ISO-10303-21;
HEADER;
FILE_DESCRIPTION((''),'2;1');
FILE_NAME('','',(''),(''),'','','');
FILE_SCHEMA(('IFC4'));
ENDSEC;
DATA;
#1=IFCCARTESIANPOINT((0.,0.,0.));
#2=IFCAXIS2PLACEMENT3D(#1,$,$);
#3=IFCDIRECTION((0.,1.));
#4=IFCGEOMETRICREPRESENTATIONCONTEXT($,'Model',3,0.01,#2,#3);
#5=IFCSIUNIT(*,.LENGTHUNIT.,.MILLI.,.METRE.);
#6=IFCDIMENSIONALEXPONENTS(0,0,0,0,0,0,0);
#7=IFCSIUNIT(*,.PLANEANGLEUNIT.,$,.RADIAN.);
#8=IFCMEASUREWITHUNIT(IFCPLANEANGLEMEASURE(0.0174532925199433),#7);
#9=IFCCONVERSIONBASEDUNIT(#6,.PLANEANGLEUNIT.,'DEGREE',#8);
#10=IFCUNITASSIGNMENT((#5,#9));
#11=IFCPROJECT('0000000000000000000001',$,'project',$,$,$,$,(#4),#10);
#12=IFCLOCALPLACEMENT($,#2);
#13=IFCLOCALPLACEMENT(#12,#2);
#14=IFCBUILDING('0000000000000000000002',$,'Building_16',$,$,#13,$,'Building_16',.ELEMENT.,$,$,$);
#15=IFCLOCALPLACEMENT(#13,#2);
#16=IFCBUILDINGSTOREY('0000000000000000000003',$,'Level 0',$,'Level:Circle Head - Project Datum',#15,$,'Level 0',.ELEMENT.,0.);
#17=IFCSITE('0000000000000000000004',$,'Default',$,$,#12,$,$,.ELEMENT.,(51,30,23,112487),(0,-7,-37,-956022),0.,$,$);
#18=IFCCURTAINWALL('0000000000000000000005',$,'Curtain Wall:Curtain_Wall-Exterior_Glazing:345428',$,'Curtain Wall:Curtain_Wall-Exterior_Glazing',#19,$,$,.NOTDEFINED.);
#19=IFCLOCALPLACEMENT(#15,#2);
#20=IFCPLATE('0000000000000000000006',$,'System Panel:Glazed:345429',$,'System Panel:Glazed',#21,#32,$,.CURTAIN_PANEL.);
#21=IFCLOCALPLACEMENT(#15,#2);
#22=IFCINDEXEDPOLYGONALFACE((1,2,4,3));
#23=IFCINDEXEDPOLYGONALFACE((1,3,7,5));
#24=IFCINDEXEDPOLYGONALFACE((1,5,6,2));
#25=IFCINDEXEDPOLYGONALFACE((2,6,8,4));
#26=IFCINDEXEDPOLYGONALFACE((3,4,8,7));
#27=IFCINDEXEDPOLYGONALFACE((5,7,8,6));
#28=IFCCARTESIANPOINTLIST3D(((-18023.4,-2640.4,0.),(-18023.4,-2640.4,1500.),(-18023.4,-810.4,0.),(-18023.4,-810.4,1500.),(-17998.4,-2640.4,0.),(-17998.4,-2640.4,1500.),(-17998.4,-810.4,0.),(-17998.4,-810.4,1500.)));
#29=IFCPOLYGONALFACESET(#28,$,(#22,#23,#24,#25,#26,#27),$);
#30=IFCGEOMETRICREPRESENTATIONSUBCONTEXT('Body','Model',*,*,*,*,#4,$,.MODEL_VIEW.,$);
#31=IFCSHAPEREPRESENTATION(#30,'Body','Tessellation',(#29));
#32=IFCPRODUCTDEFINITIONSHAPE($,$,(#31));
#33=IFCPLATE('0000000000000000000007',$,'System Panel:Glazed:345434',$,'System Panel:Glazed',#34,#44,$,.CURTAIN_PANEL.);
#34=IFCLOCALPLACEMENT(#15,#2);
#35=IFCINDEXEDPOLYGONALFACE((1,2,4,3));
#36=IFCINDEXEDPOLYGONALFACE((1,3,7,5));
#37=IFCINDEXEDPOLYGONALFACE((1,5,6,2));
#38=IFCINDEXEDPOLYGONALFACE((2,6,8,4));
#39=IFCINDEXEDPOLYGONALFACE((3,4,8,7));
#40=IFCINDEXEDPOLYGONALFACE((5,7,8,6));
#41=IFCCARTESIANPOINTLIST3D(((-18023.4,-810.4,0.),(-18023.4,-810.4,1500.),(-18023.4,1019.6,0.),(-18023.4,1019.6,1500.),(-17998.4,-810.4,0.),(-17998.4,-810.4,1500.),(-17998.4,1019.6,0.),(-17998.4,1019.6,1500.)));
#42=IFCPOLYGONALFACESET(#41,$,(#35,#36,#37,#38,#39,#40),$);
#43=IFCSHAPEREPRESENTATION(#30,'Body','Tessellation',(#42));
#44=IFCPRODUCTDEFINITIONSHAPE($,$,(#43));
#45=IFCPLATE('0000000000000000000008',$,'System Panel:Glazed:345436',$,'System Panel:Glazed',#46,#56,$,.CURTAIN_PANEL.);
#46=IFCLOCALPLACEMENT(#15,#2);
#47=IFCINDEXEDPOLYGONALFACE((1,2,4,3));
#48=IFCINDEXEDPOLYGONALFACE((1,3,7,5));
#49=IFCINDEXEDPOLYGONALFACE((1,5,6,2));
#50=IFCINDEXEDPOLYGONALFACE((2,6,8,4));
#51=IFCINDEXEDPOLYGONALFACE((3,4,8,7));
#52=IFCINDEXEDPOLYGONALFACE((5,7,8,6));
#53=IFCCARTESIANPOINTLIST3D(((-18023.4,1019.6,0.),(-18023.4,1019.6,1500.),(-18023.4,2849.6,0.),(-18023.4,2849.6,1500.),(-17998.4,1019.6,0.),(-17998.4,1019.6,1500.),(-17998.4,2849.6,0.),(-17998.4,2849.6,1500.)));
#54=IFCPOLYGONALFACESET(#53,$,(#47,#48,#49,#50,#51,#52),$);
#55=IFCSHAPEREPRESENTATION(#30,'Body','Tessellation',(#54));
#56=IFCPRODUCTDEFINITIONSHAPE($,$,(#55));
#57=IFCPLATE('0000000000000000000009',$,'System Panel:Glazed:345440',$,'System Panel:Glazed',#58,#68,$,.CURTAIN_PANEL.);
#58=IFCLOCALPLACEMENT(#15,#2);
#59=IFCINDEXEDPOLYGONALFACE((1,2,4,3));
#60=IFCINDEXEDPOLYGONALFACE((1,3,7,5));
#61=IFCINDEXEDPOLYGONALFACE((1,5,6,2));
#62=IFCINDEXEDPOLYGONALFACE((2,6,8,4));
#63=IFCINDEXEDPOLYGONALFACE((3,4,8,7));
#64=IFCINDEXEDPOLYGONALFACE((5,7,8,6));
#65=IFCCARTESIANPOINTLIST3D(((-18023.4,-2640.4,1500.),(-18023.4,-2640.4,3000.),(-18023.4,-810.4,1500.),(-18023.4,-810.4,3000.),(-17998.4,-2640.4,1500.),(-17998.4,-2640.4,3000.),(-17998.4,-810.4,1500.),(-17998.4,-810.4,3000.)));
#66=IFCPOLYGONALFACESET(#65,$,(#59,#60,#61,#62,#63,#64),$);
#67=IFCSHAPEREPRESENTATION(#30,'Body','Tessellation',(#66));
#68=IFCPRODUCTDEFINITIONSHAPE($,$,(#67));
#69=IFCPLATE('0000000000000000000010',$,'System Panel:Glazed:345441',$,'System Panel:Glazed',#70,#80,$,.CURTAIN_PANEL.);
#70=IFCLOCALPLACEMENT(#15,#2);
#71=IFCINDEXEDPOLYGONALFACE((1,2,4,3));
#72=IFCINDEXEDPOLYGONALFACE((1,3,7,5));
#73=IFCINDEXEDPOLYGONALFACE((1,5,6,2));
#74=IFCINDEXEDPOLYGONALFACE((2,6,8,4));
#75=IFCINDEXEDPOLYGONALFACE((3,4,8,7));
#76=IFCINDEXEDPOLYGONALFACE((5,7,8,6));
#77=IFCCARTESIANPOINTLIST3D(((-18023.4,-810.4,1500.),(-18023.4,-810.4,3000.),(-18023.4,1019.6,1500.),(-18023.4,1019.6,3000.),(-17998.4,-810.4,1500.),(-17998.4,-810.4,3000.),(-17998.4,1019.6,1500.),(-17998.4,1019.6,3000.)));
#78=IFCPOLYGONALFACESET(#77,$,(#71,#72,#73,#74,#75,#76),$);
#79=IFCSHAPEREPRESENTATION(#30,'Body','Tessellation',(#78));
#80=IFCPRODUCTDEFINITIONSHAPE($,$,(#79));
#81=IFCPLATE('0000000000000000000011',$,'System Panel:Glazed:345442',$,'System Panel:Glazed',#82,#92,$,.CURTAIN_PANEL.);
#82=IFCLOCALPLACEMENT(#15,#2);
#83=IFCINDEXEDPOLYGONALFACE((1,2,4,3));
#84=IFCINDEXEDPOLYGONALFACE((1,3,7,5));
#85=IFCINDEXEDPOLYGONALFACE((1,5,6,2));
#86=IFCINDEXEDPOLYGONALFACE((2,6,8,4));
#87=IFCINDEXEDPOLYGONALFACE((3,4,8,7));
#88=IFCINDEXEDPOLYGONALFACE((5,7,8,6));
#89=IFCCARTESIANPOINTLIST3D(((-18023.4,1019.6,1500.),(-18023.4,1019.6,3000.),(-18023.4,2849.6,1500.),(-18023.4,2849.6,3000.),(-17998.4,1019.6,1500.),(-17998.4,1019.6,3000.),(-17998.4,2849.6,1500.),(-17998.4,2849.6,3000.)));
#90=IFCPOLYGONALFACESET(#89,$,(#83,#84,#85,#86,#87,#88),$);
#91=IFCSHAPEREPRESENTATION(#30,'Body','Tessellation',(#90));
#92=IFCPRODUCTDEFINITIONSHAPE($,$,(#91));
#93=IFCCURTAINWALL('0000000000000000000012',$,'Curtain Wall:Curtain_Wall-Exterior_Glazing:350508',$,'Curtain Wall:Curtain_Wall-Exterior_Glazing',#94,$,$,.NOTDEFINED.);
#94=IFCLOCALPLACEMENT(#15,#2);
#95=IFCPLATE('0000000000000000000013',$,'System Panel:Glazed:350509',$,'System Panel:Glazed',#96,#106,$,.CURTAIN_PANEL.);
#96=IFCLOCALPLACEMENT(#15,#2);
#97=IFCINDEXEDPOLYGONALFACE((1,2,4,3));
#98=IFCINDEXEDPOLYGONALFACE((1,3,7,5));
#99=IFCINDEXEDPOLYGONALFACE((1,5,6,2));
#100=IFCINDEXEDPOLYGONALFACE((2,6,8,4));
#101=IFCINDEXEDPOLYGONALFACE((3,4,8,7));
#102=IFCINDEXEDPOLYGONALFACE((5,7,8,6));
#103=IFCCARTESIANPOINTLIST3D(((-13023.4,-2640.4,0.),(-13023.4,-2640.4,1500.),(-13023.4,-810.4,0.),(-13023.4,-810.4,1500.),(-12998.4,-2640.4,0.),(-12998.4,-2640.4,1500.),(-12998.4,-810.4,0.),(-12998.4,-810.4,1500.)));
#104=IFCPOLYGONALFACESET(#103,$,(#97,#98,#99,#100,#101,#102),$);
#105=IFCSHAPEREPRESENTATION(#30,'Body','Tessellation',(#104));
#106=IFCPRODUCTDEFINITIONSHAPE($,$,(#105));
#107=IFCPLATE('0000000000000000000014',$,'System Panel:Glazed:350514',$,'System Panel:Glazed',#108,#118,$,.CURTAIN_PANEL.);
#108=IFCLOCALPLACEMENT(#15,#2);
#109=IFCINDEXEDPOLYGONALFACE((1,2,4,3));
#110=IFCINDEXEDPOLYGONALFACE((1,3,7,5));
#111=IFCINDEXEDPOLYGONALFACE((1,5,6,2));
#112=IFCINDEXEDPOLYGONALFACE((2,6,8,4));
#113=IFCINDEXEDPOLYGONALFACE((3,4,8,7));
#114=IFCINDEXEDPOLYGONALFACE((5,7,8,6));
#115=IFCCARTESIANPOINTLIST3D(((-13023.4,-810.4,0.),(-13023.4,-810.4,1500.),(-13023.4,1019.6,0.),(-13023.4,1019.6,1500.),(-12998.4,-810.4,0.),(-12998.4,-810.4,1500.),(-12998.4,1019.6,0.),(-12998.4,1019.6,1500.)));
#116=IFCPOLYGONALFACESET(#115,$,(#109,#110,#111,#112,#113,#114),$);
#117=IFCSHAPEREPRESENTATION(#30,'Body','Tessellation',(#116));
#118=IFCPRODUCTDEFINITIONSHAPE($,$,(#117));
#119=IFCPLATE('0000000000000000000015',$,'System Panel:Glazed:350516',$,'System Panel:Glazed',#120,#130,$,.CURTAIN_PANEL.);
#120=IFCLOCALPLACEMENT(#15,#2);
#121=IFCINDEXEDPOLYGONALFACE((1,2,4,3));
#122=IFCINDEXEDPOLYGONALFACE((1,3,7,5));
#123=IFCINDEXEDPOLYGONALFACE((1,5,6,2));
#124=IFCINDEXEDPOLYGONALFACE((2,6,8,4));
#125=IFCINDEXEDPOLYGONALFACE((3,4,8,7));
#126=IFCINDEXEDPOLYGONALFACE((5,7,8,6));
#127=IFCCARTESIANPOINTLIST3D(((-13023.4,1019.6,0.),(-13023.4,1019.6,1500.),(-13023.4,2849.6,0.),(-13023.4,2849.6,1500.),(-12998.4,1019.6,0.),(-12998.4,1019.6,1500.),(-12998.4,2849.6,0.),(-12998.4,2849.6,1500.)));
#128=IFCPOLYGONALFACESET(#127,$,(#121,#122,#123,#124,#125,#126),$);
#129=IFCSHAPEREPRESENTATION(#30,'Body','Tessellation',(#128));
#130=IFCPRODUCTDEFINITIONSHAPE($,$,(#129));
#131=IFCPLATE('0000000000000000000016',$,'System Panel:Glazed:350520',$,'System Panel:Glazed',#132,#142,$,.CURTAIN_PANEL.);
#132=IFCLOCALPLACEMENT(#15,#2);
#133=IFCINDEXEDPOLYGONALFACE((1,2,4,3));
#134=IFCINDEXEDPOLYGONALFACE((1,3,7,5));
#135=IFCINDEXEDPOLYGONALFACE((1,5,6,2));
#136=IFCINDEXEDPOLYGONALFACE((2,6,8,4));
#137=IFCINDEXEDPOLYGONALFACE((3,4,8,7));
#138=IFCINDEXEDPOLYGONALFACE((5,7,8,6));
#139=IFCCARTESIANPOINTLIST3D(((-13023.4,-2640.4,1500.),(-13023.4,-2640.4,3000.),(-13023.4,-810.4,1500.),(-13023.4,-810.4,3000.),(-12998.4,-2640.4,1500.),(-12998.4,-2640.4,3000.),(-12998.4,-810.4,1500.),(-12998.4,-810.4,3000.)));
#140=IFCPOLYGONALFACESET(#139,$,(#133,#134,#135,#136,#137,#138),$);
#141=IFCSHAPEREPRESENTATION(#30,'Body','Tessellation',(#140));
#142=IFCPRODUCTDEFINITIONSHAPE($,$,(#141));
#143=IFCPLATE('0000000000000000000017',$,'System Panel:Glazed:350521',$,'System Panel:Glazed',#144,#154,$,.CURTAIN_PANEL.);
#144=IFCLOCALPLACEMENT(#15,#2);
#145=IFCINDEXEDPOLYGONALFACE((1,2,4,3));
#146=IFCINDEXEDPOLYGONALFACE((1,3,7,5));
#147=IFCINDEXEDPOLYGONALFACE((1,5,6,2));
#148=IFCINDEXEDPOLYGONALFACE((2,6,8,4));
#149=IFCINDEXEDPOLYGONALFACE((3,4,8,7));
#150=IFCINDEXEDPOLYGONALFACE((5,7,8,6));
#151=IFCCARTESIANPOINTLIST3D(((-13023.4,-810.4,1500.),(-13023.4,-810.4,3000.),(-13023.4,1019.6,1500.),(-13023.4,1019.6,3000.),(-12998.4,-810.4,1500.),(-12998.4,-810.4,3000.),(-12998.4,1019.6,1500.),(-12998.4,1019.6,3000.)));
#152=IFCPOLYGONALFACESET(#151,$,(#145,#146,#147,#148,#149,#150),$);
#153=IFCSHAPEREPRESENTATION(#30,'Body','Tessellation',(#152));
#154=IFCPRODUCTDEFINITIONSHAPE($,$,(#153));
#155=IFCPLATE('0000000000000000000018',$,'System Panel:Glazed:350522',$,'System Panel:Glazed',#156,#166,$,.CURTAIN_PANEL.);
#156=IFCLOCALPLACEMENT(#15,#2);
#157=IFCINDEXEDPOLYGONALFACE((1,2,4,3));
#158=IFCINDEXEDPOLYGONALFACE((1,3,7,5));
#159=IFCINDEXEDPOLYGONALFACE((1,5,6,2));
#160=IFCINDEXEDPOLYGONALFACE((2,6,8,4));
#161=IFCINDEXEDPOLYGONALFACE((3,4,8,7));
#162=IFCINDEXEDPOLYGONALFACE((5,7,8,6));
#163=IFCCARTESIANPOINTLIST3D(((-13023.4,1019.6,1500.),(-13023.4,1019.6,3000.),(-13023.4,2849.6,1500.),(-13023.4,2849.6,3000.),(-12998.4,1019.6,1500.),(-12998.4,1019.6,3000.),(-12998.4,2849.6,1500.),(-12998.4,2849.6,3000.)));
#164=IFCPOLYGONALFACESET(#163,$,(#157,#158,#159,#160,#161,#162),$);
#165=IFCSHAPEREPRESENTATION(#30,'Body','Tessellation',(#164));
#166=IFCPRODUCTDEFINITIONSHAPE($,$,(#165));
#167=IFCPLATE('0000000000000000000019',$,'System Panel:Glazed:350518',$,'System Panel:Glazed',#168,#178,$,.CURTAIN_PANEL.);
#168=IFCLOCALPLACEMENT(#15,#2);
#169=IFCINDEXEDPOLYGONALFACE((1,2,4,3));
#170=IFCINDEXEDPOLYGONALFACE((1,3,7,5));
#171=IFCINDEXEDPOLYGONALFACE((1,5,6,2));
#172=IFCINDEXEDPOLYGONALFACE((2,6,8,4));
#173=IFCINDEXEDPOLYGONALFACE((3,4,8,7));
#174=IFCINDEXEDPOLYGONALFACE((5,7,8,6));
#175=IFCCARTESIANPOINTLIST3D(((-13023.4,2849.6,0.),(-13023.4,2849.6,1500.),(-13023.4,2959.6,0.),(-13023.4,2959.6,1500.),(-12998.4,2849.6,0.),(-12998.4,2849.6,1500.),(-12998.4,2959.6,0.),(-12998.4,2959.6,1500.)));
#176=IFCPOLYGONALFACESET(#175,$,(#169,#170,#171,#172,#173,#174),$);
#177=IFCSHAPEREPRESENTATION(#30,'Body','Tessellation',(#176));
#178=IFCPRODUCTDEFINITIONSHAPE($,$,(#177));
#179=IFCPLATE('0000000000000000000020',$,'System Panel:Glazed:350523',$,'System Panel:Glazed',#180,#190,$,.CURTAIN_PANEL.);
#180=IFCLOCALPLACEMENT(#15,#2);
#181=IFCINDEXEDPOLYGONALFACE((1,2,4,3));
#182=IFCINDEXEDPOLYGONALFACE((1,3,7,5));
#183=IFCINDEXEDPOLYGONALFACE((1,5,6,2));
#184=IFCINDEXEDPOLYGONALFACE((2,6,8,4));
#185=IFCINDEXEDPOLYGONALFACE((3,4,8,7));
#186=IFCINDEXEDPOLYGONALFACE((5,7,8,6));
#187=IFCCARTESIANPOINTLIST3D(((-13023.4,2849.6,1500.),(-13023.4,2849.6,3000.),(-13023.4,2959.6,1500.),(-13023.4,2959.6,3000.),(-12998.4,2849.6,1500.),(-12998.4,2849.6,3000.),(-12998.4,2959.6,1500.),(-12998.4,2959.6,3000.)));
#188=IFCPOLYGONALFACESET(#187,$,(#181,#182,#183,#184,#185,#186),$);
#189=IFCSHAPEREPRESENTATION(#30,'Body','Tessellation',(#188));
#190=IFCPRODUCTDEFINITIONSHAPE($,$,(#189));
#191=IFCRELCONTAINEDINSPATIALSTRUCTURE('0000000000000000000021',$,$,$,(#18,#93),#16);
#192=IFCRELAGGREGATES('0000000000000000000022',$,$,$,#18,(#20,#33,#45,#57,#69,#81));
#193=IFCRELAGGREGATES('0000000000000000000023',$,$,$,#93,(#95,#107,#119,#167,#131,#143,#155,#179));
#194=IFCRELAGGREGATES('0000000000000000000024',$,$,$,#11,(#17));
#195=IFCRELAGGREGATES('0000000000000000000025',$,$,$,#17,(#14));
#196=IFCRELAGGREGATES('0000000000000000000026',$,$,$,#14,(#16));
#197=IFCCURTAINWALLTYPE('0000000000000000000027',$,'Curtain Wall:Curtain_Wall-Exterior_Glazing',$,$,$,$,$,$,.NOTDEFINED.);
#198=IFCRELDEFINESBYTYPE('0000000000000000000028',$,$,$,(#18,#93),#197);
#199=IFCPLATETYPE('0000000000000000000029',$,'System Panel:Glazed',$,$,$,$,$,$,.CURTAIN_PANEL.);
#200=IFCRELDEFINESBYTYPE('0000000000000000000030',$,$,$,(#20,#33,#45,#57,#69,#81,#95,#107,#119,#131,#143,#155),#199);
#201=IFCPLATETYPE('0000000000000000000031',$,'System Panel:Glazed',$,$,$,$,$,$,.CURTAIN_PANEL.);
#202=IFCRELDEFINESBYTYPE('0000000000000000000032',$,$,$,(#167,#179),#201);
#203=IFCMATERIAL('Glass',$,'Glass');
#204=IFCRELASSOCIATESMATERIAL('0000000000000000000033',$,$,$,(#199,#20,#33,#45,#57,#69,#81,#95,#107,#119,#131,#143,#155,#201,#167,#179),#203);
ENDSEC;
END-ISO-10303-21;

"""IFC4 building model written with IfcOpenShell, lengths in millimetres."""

from ifc_helpers import new_model, entity, si_unit, converted_unit, direction, frame, origin, place, context, subcontext, project, spatial, indexed_curve, outline, extrude, source, transform, mapped, material, type_object, type_shapes, element, aggregate, save


model = new_model("IFC4")

# Units and contexts
model_context = context("Model", 3, precision=0.01, world=origin(), true_north=direction((0.0, 1.0)))
body_context = subcontext(model_context, "Body", "Model", "MODEL_VIEW")
ifc_project = project(units=[si_unit("LENGTHUNIT", "METRE", prefix="MILLI"), converted_unit("PLANEANGLEUNIT", "DEGREE", entity("IfcPlaneAngleMeasure", 0.0174532925199433), si_unit("PLANEANGLEUNIT", "RADIAN"), dimensions=[0, 0, 0, 0, 0, 0, 0])], contexts=[model_context])

# Site, building, storey
site_placement = place(None, origin())
site = spatial("IfcSite", under=ifc_project, at=site_placement, Name="Default", CompositionType="ELEMENT", RefLatitude=(51, 30, 23, 112487), RefLongitude=(0, -7, -37, -956022), RefElevation=0.0)
building_placement = place(site_placement, origin())
building = spatial("IfcBuilding", under=site, at=building_placement, Name="Building_16", LongName="Building_16", CompositionType="ELEMENT")
storey_placement = place(building_placement, origin())
storey = spatial("IfcBuildingStorey", under=building, at=storey_placement, Name="Level 0", ObjectType="Level:Circle Head - Project Datum", LongName="Level 0", CompositionType="ELEMENT", Elevation=0.0)

# Curtain walls, plates
curtain_wall_type = type_object("IfcCurtainWallType", Name="Curtain Wall:Curtain_Wall-Exterior_Glazing", PredefinedType="NOTDEFINED")
curtain_wall_1_placement = place(storey_placement, origin())
curtain_wall_1 = element("IfcCurtainWall", 1, at=curtain_wall_1_placement, inside=storey, type_object=curtain_wall_type, Name="Curtain Wall:Curtain_Wall-Exterior_Glazing:345428", ObjectType="Curtain Wall:Curtain_Wall-Exterior_Glazing", PredefinedType="NOTDEFINED")
ifc_material = material(Name="Glass", Category="Glass")
plate_type_1 = type_object("IfcPlateType", Name="System Panel:Glazed", PredefinedType="CURTAIN_PANEL", material=ifc_material)
shared_shape_1 = source(origin(), body_context, "Body", "SweptSolid", [
    extrude(outline(indexed_curve([(-12.5, -915.0), (12.5, -915.0), (12.5, 915.0), (-12.5, 915.0), (-12.5, -915.0)], self_intersect=False)), frame((0.0, 37.0, 0.0), z_axis=(0.0, 0.0, 1.0), x_axis=(0.0, 1.0, 0.0)), (0.0, 0.0, 1.0), 1500.0),
])
type_shapes(plate_type_1, [shared_shape_1])
plate_1_placement = place(curtain_wall_1_placement, frame((-17973.9, -1725.4, 0.0), z_axis=(0.0, 0.0, 1.0), x_axis=(0.0, 1.0, 0.0)))
plate_1 = element("IfcPlate", 2, at=plate_1_placement, type_object=plate_type_1, material=ifc_material, Name="System Panel:Glazed:345429", ObjectType="System Panel:Glazed", PredefinedType="CURTAIN_PANEL", context=body_context, shape_type="MappedRepresentation", body=[
    mapped(shared_shape_1, transform((0.0, 0.0, 0.0), scale=1.0)),
])
plate_2_placement = place(curtain_wall_1_placement, frame((-17973.9, 104.6, 0.0), z_axis=(0.0, 0.0, 1.0), x_axis=(0.0, 1.0, 0.0)))
plate_2 = element("IfcPlate", 3, at=plate_2_placement, type_object=plate_type_1, material=ifc_material, Name="System Panel:Glazed:345434", ObjectType="System Panel:Glazed", PredefinedType="CURTAIN_PANEL", context=body_context, shape_type="MappedRepresentation", body=[
    mapped(shared_shape_1, transform((0.0, 0.0, 0.0), scale=1.0)),
])
plate_3_placement = place(curtain_wall_1_placement, frame((-17973.9, 1934.6, 0.0), z_axis=(0.0, 0.0, 1.0), x_axis=(0.0, 1.0, 0.0)))
plate_3 = element("IfcPlate", 4, at=plate_3_placement, type_object=plate_type_1, material=ifc_material, Name="System Panel:Glazed:345436", ObjectType="System Panel:Glazed", PredefinedType="CURTAIN_PANEL", context=body_context, shape_type="MappedRepresentation", body=[
    mapped(shared_shape_1, transform((0.0, 0.0, 0.0), scale=1.0)),
])
plate_4_placement = place(curtain_wall_1_placement, frame((-17973.9, -1725.4, 1500.0), z_axis=(0.0, 0.0, 1.0), x_axis=(0.0, 1.0, 0.0)))
plate_4 = element("IfcPlate", 5, at=plate_4_placement, type_object=plate_type_1, material=ifc_material, Name="System Panel:Glazed:345440", ObjectType="System Panel:Glazed", PredefinedType="CURTAIN_PANEL", context=body_context, shape_type="MappedRepresentation", body=[
    mapped(shared_shape_1, transform((0.0, 0.0, 0.0), scale=1.0)),
])
plate_5_placement = place(curtain_wall_1_placement, frame((-17973.9, 104.6, 1500.0), z_axis=(0.0, 0.0, 1.0), x_axis=(0.0, 1.0, 0.0)))
plate_5 = element("IfcPlate", 6, at=plate_5_placement, type_object=plate_type_1, material=ifc_material, Name="System Panel:Glazed:345441", ObjectType="System Panel:Glazed", PredefinedType="CURTAIN_PANEL", context=body_context, shape_type="MappedRepresentation", body=[
    mapped(shared_shape_1, transform((0.0, 0.0, 0.0), scale=1.0)),
])
plate_6_placement = place(curtain_wall_1_placement, frame((-17973.9, 1934.6, 1500.0), z_axis=(0.0, 0.0, 1.0), x_axis=(0.0, 1.0, 0.0)))
plate_6 = element("IfcPlate", 7, at=plate_6_placement, type_object=plate_type_1, material=ifc_material, Name="System Panel:Glazed:345442", ObjectType="System Panel:Glazed", PredefinedType="CURTAIN_PANEL", context=body_context, shape_type="MappedRepresentation", body=[
    mapped(shared_shape_1, transform((0.0, 0.0, 0.0), scale=1.0)),
])
curtain_wall_2_placement = place(storey_placement, origin())
curtain_wall_2 = element("IfcCurtainWall", 8, at=curtain_wall_2_placement, inside=storey, type_object=curtain_wall_type, Name="Curtain Wall:Curtain_Wall-Exterior_Glazing:350508", ObjectType="Curtain Wall:Curtain_Wall-Exterior_Glazing", PredefinedType="NOTDEFINED")
plate_7_placement = place(curtain_wall_2_placement, frame((-12973.9, -1725.4, 0.0), z_axis=(0.0, 0.0, 1.0), x_axis=(0.0, 1.0, 0.0)))
plate_7 = element("IfcPlate", 9, at=plate_7_placement, type_object=plate_type_1, material=ifc_material, Name="System Panel:Glazed:350509", ObjectType="System Panel:Glazed", PredefinedType="CURTAIN_PANEL", context=body_context, shape_type="MappedRepresentation", body=[
    mapped(shared_shape_1, transform((0.0, 0.0, 0.0), scale=1.0)),
])
plate_8_placement = place(curtain_wall_2_placement, frame((-12973.9, 104.6, 0.0), z_axis=(0.0, 0.0, 1.0), x_axis=(0.0, 1.0, 0.0)))
plate_8 = element("IfcPlate", 10, at=plate_8_placement, type_object=plate_type_1, material=ifc_material, Name="System Panel:Glazed:350514", ObjectType="System Panel:Glazed", PredefinedType="CURTAIN_PANEL", context=body_context, shape_type="MappedRepresentation", body=[
    mapped(shared_shape_1, transform((0.0, 0.0, 0.0), scale=1.0)),
])
plate_9_placement = place(curtain_wall_2_placement, frame((-12973.9, 1934.6, 0.0), z_axis=(0.0, 0.0, 1.0), x_axis=(0.0, 1.0, 0.0)))
plate_9 = element("IfcPlate", 11, at=plate_9_placement, type_object=plate_type_1, material=ifc_material, Name="System Panel:Glazed:350516", ObjectType="System Panel:Glazed", PredefinedType="CURTAIN_PANEL", context=body_context, shape_type="MappedRepresentation", body=[
    mapped(shared_shape_1, transform((0.0, 0.0, 0.0), scale=1.0)),
])
plate_10_placement = place(curtain_wall_2_placement, frame((-12973.9, -1725.4, 1500.0), z_axis=(0.0, 0.0, 1.0), x_axis=(0.0, 1.0, 0.0)))
plate_10 = element("IfcPlate", 12, at=plate_10_placement, type_object=plate_type_1, material=ifc_material, Name="System Panel:Glazed:350520", ObjectType="System Panel:Glazed", PredefinedType="CURTAIN_PANEL", context=body_context, shape_type="MappedRepresentation", body=[
    mapped(shared_shape_1, transform((0.0, 0.0, 0.0), scale=1.0)),
])
plate_11_placement = place(curtain_wall_2_placement, frame((-12973.9, 104.6, 1500.0), z_axis=(0.0, 0.0, 1.0), x_axis=(0.0, 1.0, 0.0)))
plate_11 = element("IfcPlate", 13, at=plate_11_placement, type_object=plate_type_1, material=ifc_material, Name="System Panel:Glazed:350521", ObjectType="System Panel:Glazed", PredefinedType="CURTAIN_PANEL", context=body_context, shape_type="MappedRepresentation", body=[
    mapped(shared_shape_1, transform((0.0, 0.0, 0.0), scale=1.0)),
])
plate_12_placement = place(curtain_wall_2_placement, frame((-12973.9, 1934.6, 1500.0), z_axis=(0.0, 0.0, 1.0), x_axis=(0.0, 1.0, 0.0)))
plate_12 = element("IfcPlate", 14, at=plate_12_placement, type_object=plate_type_1, material=ifc_material, Name="System Panel:Glazed:350522", ObjectType="System Panel:Glazed", PredefinedType="CURTAIN_PANEL", context=body_context, shape_type="MappedRepresentation", body=[
    mapped(shared_shape_1, transform((0.0, 0.0, 0.0), scale=1.0)),
])
plate_type_2 = type_object("IfcPlateType", Name="System Panel:Glazed", PredefinedType="CURTAIN_PANEL", material=ifc_material)
shared_shape_2 = source(origin(), body_context, "Body", "SweptSolid", [
    extrude(outline(indexed_curve([(-12.5, -55.0), (12.5, -55.0), (12.5, 55.0), (-12.5, 55.0), (-12.5, -55.0)], self_intersect=False)), frame((0.0, 37.0, 0.0), z_axis=(0.0, 0.0, 1.0), x_axis=(0.0, 1.0, 0.0)), (0.0, 0.0, 1.0), 1500.0),
])
type_shapes(plate_type_2, [shared_shape_2])
plate_13_placement = place(curtain_wall_2_placement, frame((-12973.9, 2904.6, 0.0), z_axis=(0.0, 0.0, 1.0), x_axis=(0.0, 1.0, 0.0)))
plate_13 = element("IfcPlate", 15, at=plate_13_placement, type_object=plate_type_2, material=ifc_material, Name="System Panel:Glazed:350518", ObjectType="System Panel:Glazed", PredefinedType="CURTAIN_PANEL", context=body_context, shape_type="MappedRepresentation", body=[
    mapped(shared_shape_2, transform((0.0, 0.0, 0.0), scale=1.0)),
])
plate_14_placement = place(curtain_wall_2_placement, frame((-12973.9, 2904.6, 1500.0), z_axis=(0.0, 0.0, 1.0), x_axis=(0.0, 1.0, 0.0)))
plate_14 = element("IfcPlate", 16, at=plate_14_placement, type_object=plate_type_2, material=ifc_material, Name="System Panel:Glazed:350523", ObjectType="System Panel:Glazed", PredefinedType="CURTAIN_PANEL", context=body_context, shape_type="MappedRepresentation", body=[
    mapped(shared_shape_2, transform((0.0, 0.0, 0.0), scale=1.0)),
])

aggregate(curtain_wall_1, [plate_1, plate_2, plate_3, plate_4, plate_5, plate_6])
aggregate(curtain_wall_2, [plate_7, plate_8, plate_9, plate_13, plate_10, plate_11, plate_12, plate_14])

save(model, "model.ifc")
